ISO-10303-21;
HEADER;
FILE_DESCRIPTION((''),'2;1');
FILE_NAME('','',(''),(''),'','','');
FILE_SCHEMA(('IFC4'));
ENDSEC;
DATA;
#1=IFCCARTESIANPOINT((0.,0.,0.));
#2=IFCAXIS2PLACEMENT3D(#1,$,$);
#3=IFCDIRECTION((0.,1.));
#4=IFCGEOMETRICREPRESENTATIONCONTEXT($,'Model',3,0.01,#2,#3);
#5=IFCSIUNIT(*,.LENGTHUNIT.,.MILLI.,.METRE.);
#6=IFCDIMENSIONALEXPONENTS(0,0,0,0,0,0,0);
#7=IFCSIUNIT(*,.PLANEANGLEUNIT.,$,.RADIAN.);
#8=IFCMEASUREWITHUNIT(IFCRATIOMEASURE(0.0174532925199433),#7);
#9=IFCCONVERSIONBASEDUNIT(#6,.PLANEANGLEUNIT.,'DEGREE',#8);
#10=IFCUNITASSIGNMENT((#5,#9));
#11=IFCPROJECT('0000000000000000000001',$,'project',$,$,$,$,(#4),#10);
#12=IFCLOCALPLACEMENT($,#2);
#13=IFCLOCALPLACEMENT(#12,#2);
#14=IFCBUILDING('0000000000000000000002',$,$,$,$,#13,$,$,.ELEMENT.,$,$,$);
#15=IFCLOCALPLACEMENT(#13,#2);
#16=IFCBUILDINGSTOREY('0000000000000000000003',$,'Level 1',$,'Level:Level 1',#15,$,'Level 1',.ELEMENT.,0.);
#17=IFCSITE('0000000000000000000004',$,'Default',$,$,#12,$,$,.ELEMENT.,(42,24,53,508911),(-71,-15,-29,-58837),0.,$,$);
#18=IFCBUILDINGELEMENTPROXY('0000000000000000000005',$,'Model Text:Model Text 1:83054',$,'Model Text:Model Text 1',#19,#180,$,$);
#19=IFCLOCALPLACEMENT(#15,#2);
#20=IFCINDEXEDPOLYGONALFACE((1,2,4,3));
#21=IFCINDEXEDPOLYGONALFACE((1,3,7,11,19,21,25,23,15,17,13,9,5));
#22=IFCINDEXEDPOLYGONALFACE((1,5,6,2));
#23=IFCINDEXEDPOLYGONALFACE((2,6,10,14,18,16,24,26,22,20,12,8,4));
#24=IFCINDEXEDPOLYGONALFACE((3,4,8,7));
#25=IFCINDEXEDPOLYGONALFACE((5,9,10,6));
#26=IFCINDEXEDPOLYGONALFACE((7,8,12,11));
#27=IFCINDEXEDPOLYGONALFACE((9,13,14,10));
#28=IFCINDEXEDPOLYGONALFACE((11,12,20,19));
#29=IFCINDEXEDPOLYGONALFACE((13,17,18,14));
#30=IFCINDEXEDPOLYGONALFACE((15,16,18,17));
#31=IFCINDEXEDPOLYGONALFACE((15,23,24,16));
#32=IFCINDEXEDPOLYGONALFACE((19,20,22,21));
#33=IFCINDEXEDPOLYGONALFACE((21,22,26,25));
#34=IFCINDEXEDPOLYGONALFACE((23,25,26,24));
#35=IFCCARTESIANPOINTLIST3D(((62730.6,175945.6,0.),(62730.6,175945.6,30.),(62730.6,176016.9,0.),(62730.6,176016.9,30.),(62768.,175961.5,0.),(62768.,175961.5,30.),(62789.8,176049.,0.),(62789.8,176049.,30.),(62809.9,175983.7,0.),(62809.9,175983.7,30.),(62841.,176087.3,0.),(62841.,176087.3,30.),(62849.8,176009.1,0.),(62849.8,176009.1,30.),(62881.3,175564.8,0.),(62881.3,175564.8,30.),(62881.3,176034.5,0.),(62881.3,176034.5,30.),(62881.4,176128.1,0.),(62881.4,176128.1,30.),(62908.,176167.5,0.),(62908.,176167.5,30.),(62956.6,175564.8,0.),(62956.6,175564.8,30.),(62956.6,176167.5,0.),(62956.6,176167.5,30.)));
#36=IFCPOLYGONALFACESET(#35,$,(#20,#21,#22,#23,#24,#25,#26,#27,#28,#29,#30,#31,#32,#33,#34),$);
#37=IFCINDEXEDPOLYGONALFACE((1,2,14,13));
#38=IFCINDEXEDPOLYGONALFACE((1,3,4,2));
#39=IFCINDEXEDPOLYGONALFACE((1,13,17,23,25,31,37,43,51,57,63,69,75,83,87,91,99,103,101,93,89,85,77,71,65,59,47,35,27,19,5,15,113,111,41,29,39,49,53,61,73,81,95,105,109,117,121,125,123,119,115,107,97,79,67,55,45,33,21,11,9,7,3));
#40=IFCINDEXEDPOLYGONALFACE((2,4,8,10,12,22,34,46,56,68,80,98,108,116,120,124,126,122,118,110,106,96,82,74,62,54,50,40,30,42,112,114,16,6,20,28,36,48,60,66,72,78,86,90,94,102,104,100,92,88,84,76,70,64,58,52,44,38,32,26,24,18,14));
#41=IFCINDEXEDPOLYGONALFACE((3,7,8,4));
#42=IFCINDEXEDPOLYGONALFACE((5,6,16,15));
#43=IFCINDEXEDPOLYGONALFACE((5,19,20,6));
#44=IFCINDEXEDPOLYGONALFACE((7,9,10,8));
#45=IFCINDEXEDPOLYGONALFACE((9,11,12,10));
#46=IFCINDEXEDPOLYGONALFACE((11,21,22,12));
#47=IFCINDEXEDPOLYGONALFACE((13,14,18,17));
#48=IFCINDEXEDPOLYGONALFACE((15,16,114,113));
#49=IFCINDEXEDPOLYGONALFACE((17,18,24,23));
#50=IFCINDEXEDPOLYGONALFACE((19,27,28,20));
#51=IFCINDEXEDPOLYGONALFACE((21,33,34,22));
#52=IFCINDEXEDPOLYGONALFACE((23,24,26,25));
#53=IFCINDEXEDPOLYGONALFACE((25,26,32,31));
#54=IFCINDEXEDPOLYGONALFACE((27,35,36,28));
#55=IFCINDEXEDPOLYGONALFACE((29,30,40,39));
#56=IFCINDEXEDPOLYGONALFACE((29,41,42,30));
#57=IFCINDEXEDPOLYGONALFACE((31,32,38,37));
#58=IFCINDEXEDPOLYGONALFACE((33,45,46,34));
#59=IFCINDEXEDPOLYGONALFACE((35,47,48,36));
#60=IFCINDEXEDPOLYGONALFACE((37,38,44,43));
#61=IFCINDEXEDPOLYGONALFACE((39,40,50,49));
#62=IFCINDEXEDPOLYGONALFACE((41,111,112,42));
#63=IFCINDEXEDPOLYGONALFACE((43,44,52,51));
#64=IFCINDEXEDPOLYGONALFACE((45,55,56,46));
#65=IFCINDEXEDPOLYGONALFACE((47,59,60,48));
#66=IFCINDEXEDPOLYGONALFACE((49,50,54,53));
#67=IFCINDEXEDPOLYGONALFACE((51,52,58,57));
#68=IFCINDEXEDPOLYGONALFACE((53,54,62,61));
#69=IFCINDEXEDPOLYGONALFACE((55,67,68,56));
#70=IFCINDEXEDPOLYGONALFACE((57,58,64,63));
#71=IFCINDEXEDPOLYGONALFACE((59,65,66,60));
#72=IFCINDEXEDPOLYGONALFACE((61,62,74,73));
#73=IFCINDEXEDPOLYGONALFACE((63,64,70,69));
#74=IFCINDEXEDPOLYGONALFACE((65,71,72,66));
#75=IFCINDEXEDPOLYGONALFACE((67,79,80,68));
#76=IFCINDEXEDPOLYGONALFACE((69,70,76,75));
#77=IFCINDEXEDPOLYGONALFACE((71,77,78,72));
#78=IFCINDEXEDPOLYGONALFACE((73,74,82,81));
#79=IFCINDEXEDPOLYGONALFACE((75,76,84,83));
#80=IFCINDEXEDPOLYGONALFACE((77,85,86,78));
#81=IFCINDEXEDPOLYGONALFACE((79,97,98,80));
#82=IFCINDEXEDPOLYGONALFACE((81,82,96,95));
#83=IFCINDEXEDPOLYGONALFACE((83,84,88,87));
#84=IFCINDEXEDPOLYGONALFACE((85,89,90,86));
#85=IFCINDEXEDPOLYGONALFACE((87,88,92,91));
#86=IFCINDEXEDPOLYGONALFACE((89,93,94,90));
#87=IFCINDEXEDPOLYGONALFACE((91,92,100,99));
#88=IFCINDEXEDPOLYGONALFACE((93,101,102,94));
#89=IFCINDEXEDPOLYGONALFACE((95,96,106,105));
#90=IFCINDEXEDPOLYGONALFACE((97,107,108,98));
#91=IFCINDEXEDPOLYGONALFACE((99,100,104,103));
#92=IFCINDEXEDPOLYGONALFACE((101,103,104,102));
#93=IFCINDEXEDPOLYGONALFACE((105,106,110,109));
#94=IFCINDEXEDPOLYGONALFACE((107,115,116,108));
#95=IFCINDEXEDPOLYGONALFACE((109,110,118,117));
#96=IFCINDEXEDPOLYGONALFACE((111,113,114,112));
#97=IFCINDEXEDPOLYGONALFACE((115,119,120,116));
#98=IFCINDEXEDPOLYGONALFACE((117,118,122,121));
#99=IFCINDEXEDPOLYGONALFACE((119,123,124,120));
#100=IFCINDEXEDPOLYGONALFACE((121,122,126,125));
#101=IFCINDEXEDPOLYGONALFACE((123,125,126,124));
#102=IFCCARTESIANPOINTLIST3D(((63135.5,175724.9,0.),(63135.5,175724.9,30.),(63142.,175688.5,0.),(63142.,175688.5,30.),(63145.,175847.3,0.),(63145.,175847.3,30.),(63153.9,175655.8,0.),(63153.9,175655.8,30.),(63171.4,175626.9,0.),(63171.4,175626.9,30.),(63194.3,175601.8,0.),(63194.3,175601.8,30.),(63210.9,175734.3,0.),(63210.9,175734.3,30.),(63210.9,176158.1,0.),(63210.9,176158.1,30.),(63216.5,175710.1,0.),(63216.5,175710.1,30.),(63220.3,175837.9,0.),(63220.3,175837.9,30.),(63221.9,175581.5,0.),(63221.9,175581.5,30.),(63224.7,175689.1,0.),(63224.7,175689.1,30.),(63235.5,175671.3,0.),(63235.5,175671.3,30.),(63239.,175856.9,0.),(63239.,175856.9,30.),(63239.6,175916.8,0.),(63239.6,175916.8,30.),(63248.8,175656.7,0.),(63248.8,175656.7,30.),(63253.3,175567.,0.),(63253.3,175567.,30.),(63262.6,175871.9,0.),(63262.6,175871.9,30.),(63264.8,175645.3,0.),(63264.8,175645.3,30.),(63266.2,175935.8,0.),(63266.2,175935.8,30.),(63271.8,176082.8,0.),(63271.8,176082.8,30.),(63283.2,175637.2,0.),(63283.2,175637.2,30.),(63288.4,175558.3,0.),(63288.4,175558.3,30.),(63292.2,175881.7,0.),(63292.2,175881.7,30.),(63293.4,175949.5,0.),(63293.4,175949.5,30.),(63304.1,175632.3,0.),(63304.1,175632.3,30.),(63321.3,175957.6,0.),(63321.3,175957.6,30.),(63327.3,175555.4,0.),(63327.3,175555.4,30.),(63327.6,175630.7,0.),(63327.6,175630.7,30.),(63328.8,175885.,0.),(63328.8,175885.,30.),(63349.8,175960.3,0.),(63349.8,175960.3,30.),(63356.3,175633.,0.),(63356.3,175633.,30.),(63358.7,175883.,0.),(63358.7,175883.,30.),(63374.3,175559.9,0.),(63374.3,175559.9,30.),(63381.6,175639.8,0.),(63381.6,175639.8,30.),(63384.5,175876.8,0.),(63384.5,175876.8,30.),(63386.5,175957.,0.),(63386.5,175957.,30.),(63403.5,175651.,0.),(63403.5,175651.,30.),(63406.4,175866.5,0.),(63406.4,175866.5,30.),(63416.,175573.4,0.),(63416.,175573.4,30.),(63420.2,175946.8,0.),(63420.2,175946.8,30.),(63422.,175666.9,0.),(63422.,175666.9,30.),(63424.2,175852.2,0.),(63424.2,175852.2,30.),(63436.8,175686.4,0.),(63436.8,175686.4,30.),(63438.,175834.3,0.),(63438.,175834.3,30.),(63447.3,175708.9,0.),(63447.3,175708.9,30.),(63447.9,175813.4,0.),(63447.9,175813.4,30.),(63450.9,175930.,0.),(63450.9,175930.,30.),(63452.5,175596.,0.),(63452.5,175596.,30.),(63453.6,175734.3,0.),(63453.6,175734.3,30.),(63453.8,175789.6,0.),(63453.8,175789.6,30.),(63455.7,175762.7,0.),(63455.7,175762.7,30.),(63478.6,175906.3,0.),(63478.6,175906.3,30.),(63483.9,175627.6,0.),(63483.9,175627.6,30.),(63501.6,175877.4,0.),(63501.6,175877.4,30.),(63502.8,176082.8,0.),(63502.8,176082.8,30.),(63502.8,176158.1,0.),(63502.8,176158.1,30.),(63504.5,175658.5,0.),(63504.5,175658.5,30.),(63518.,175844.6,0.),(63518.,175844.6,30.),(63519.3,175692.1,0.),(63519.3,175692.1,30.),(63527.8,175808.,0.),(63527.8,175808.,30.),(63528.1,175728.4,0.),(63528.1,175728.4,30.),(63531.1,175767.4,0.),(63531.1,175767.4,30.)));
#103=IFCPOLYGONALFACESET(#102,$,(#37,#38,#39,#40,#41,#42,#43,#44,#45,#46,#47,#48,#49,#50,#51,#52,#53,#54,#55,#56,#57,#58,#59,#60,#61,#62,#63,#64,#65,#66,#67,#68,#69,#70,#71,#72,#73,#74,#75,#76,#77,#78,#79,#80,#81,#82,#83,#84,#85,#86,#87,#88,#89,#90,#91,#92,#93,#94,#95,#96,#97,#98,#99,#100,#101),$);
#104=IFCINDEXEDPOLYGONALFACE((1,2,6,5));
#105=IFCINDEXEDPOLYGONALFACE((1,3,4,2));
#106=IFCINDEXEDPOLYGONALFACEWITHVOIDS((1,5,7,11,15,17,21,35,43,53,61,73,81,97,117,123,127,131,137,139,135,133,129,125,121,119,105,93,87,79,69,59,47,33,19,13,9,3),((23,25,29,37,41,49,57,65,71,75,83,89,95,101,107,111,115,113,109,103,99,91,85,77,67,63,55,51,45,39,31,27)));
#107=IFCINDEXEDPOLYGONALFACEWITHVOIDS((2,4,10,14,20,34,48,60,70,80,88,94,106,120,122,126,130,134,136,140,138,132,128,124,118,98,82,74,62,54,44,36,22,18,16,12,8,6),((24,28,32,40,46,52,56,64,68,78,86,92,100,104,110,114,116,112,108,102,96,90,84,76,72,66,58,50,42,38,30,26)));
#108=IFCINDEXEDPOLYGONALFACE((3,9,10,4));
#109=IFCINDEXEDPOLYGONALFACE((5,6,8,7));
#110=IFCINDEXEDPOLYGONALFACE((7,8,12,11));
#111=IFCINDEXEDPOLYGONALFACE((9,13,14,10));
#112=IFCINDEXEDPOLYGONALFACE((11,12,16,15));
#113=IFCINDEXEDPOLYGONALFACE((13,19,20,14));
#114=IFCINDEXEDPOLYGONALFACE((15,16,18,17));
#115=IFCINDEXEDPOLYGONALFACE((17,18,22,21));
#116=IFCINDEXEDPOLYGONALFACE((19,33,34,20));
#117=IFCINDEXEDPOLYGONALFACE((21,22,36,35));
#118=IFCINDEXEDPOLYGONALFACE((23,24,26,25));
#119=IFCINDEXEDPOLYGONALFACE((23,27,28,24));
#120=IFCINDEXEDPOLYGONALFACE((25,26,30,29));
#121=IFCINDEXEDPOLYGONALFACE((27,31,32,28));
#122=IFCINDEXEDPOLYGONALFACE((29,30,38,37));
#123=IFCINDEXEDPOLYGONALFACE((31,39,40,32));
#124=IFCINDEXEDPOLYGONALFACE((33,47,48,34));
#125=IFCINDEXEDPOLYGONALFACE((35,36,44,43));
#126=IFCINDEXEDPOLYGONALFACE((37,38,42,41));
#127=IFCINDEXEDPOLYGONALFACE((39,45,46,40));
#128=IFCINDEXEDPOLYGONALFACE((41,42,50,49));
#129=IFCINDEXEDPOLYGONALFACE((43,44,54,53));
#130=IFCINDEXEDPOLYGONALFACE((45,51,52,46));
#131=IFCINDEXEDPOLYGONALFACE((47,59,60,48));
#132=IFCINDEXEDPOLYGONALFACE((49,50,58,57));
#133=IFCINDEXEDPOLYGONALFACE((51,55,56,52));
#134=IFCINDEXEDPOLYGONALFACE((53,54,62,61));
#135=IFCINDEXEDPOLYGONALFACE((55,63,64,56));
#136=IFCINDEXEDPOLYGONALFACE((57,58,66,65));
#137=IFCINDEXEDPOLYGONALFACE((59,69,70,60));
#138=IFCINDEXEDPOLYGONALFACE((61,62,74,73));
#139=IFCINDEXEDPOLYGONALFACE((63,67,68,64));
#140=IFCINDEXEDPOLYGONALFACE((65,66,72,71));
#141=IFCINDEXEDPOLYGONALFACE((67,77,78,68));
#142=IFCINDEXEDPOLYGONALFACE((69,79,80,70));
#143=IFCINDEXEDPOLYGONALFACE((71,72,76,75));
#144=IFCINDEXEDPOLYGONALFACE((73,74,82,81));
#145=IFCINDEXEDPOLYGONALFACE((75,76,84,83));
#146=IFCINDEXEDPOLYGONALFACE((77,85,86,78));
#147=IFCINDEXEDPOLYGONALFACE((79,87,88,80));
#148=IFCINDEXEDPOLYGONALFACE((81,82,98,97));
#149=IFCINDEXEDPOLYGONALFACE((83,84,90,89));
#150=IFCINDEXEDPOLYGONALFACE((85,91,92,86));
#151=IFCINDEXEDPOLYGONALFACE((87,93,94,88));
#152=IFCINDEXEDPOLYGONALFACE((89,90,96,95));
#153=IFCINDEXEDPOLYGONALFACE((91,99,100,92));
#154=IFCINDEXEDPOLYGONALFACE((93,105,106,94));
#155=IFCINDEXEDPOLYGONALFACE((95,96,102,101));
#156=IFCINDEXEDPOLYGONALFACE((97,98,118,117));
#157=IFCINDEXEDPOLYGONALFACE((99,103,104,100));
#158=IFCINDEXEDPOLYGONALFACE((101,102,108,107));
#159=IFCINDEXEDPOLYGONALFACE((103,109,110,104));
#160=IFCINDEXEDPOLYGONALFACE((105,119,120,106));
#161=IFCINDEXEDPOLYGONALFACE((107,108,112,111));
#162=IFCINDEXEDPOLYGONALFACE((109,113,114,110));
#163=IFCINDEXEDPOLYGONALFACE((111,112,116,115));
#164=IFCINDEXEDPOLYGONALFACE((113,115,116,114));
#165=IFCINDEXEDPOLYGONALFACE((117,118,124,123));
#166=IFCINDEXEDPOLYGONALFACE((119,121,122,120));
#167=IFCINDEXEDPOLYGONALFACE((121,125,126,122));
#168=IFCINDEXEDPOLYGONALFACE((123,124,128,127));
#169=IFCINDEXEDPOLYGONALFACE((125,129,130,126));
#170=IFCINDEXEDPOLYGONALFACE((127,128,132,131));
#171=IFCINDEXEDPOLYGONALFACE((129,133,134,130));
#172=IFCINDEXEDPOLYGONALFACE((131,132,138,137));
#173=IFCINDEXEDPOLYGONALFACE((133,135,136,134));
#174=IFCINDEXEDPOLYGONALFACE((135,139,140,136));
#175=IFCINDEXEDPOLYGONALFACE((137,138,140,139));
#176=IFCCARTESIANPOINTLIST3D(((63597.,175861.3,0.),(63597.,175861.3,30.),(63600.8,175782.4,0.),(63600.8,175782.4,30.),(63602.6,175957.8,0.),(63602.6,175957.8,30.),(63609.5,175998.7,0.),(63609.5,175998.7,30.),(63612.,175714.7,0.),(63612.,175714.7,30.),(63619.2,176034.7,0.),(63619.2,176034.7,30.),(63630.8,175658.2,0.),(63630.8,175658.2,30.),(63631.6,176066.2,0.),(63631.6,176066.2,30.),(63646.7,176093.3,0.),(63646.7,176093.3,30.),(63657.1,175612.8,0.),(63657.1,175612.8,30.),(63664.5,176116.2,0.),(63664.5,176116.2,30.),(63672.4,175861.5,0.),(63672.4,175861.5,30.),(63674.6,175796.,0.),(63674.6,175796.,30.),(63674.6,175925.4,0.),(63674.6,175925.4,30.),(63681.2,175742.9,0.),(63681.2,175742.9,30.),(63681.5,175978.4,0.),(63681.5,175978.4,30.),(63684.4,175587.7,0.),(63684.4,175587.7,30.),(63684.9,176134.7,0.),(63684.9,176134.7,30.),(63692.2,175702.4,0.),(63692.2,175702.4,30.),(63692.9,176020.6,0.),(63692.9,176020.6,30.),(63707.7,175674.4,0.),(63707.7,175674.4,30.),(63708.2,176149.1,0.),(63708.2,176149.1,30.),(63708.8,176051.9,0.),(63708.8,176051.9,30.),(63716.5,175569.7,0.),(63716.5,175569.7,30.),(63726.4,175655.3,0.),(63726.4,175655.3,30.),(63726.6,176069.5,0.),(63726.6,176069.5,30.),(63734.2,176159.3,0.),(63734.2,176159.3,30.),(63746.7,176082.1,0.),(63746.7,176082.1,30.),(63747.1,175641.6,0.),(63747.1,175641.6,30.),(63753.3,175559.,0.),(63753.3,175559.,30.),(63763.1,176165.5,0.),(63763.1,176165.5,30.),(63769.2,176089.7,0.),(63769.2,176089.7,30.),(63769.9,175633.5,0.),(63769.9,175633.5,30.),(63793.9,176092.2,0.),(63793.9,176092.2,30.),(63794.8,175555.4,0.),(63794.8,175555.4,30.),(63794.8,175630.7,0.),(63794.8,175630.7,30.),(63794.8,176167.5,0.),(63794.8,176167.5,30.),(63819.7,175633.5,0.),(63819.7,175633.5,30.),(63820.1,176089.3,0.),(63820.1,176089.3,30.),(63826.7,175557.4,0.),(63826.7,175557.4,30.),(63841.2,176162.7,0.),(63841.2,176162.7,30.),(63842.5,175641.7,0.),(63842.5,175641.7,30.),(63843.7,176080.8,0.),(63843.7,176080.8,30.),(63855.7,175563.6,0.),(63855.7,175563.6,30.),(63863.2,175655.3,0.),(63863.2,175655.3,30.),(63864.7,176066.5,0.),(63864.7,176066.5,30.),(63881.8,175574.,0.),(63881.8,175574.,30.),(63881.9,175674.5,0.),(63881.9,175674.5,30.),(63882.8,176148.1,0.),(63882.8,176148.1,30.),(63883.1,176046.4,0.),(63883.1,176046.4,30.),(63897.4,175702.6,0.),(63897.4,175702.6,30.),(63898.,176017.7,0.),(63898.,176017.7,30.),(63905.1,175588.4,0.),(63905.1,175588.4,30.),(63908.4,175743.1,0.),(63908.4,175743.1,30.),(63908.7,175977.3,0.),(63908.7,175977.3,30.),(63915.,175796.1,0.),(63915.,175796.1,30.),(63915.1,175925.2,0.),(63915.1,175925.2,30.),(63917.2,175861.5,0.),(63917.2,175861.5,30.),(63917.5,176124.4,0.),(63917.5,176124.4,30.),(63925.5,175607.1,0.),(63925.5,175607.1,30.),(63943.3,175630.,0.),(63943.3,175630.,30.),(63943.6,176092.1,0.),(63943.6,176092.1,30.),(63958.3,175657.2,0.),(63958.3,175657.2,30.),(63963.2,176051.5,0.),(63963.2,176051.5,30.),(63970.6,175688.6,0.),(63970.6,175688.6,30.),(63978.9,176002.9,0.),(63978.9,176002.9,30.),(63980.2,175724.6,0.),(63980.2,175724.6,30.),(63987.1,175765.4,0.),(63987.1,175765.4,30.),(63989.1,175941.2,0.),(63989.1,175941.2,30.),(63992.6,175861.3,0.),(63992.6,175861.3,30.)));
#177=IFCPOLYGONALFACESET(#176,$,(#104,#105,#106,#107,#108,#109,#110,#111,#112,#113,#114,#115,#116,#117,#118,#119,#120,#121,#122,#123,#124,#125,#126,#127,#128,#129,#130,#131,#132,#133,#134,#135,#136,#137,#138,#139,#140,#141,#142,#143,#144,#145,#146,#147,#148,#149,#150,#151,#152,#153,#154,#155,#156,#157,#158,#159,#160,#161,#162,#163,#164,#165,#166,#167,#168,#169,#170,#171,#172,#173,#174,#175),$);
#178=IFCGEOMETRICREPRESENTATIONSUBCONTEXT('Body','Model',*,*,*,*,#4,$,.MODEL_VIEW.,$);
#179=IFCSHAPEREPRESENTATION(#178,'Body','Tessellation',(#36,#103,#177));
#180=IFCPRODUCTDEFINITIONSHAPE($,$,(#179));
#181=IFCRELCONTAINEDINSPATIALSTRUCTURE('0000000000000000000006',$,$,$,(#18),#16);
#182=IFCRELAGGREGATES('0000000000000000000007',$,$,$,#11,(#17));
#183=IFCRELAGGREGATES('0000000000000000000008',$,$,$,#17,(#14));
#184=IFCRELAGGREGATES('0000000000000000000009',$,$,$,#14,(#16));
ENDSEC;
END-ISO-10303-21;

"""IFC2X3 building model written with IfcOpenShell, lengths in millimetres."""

from ifc_helpers import new_model, entity, si_unit, converted_unit, direction, frame, origin, place, context, subcontext, project, spatial, polyline, outline, extrude, element, save


model = new_model("IFC2X3")

# Units and contexts
model_context = context("Model", 3, precision=0.01, world=origin(), true_north=direction((0.0, 1.0)))
body_context = subcontext(model_context, "Body", "Model", "MODEL_VIEW")
ifc_project = project(units=[si_unit("LENGTHUNIT", "METRE", prefix="MILLI"), converted_unit("PLANEANGLEUNIT", "DEGREE", entity("IfcRatioMeasure", 0.0174532925199433), si_unit("PLANEANGLEUNIT", "RADIAN"), dimensions=[0, 0, 0, 0, 0, 0, 0])], contexts=[model_context])

# Site, building, storey
site_placement = place(None, origin())
site = spatial("IfcSite", under=ifc_project, at=site_placement, Name="Default", CompositionType="ELEMENT", RefLatitude=(42, 24, 53, 508911), RefLongitude=(-71, -15, -29, -58837), RefElevation=0.0)
building_placement = place(site_placement, origin())
building = spatial("IfcBuilding", under=site, at=building_placement, CompositionType="ELEMENT")
storey_placement = place(building_placement, origin())
storey = spatial("IfcBuildingStorey", under=building, at=storey_placement, Name="Level 1", ObjectType="Level:Level 1", LongName="Level 1", CompositionType="ELEMENT", Elevation=0.0)

# Building element proxy
proxy_1_placement = place(storey_placement, origin())
element("IfcBuildingElementProxy", 1, at=proxy_1_placement, inside=storey, Name="Model Text:Model Text 1:83054", ObjectType="Model Text:Model Text 1", context=body_context, shape_type="SweptSolid", body=[
    extrude(outline(polyline([(-410.6, -111.6), (192.1, -111.6), (192.1, -63.1), (152.7, -36.4), (111.9, 4.0), (73.6, 55.2), (41.4, 114.4), (-29.8, 114.4), (-13.9, 77.0), (8.3, 35.1), (33.7, -4.8), (59.1, -36.3), (-410.6, -36.3), (-410.6, -111.6)])), frame((62845.0, 175975.4, 0.0), z_axis=(0.0, 0.0, 1.0), x_axis=(0.0, 1.0, 0.0)), (0.0, 0.0, 1.0), 30.0),
    extrude(outline(polyline([(12.1, -219.3), (49.1, -219.3), (83.4, -213.2), (114.8, -201.1), (143.5, -182.8), (168.3, -159.2), (188.1, -130.8), (202.8, -97.8), (212.4, -60.0), (216.1, -12.9), (210.0, 30.5), (194.1, 70.4), (168.4, 106.8), (141.6, 132.5), (111.1, 152.9), (76.9, 167.9), (39.0, 177.6), (-1.5, 181.4), (-39.3, 178.1), (-74.4, 167.6), (-106.9, 150.1), (-135.0, 126.9), (-157.0, 99.6), (-172.8, 68.1), (-182.5, 32.6), (-184.8, 4.0), (-181.6, -24.8), (-172.9, -54.0), (-158.8, -83.5), (-316.6, -22.9), (-276.5, 204.6), (-350.7, 217.7), (-401.4, -69.8), (-106.8, -188.8), (-84.5, -116.2), (-99.9, -94.5), (-110.6, -68.6), (-115.1, -37.8), (-112.0, -1.2), (-104.8, 27.9), (-94.2, 52.3), (-80.3, 72.0), (-63.1, 87.0), (-43.0, 97.5), (-20.8, 103.6), (3.8, 105.3), (30.5, 102.6), (58.1, 95.6), (82.1, 84.9), (102.4, 70.6), (119.1, 52.7), (131.4, 31.7), (138.7, 8.2), (141.0, -17.9), (138.2, -46.6), (132.6, -69.4), (124.1, -89.2), (112.9, -105.9), (99.0, -119.6), (82.3, -130.2), (62.9, -137.7), (40.8, -142.2), (15.9, -143.5), (12.1, -219.3)])), frame((63349.4, 175775.0, 0.0), z_axis=(0.0, 0.0, 1.0), x_axis=(0.173842, -0.984774, 0.0)), (0.0, 0.0, 1.0), 30.0),
    extrude(outline(polyline([(-10.6, -198.7), (68.3, -198.7), (136.5, -190.7), (193.9, -174.7), (240.5, -150.6), (266.9, -124.4), (286.3, -93.2), (298.8, -57.0), (304.3, -15.7), (303.8, 16.2), (299.0, 45.5), (289.9, 72.1), (276.6, 96.0), (258.9, 117.3), (236.9, 136.2), (210.4, 152.5), (179.6, 166.3), (144.1, 177.6), (103.7, 186.3), (8.2, 196.4), (-71.8, 196.7), (-134.0, 189.4), (-183.3, 176.1), (-224.7, 158.4), (-258.2, 133.9), (-283.5, 100.3), (-300.1, 59.5), (-307.1, 13.4), (-306.6, -18.4), (-301.8, -47.5), (-292.8, -74.0), (-279.6, -97.9), (-262.0, -119.2), (-240.0, -138.1), (-213.6, -154.5), (-182.8, -168.4), (-147.3, -179.8), (-106.7, -188.6), (-10.6, -198.7)]), holes=[polyline([(-7.2, -123.5), (-71.0, -118.2), (-123.6, -108.8), (-165.2, -95.4), (-195.7, -78.0), (-212.4, -59.4), (-224.1, -38.7), (-230.6, -15.9), (-231.9, 8.9), (-227.8, 35.0), (-218.1, 58.1), (-202.8, 78.4), (-182.0, 95.8), (-152.6, 109.4), (-111.7, 118.1), (-59.4, 122.0), (4.4, 121.1), (69.6, 115.8), (122.2, 106.7), (162.2, 93.7), (189.5, 77.0), (207.7, 57.4), (220.4, 36.0), (227.5, 12.8), (229.1, -12.1), (225.2, -36.8), (215.9, -59.2), (201.3, -79.3), (181.4, -97.1), (152.6, -111.2), (111.6, -120.3), (58.3, -124.4), (-7.2, -123.5)])]), frame((63796.0, 175860.1, 0.0), z_axis=(0.0, 0.0, 1.0), x_axis=(0.047515, -0.998871, 0.0)), (0.0, 0.0, 1.0), 30.0),
])

save(model, "model.ifc")
